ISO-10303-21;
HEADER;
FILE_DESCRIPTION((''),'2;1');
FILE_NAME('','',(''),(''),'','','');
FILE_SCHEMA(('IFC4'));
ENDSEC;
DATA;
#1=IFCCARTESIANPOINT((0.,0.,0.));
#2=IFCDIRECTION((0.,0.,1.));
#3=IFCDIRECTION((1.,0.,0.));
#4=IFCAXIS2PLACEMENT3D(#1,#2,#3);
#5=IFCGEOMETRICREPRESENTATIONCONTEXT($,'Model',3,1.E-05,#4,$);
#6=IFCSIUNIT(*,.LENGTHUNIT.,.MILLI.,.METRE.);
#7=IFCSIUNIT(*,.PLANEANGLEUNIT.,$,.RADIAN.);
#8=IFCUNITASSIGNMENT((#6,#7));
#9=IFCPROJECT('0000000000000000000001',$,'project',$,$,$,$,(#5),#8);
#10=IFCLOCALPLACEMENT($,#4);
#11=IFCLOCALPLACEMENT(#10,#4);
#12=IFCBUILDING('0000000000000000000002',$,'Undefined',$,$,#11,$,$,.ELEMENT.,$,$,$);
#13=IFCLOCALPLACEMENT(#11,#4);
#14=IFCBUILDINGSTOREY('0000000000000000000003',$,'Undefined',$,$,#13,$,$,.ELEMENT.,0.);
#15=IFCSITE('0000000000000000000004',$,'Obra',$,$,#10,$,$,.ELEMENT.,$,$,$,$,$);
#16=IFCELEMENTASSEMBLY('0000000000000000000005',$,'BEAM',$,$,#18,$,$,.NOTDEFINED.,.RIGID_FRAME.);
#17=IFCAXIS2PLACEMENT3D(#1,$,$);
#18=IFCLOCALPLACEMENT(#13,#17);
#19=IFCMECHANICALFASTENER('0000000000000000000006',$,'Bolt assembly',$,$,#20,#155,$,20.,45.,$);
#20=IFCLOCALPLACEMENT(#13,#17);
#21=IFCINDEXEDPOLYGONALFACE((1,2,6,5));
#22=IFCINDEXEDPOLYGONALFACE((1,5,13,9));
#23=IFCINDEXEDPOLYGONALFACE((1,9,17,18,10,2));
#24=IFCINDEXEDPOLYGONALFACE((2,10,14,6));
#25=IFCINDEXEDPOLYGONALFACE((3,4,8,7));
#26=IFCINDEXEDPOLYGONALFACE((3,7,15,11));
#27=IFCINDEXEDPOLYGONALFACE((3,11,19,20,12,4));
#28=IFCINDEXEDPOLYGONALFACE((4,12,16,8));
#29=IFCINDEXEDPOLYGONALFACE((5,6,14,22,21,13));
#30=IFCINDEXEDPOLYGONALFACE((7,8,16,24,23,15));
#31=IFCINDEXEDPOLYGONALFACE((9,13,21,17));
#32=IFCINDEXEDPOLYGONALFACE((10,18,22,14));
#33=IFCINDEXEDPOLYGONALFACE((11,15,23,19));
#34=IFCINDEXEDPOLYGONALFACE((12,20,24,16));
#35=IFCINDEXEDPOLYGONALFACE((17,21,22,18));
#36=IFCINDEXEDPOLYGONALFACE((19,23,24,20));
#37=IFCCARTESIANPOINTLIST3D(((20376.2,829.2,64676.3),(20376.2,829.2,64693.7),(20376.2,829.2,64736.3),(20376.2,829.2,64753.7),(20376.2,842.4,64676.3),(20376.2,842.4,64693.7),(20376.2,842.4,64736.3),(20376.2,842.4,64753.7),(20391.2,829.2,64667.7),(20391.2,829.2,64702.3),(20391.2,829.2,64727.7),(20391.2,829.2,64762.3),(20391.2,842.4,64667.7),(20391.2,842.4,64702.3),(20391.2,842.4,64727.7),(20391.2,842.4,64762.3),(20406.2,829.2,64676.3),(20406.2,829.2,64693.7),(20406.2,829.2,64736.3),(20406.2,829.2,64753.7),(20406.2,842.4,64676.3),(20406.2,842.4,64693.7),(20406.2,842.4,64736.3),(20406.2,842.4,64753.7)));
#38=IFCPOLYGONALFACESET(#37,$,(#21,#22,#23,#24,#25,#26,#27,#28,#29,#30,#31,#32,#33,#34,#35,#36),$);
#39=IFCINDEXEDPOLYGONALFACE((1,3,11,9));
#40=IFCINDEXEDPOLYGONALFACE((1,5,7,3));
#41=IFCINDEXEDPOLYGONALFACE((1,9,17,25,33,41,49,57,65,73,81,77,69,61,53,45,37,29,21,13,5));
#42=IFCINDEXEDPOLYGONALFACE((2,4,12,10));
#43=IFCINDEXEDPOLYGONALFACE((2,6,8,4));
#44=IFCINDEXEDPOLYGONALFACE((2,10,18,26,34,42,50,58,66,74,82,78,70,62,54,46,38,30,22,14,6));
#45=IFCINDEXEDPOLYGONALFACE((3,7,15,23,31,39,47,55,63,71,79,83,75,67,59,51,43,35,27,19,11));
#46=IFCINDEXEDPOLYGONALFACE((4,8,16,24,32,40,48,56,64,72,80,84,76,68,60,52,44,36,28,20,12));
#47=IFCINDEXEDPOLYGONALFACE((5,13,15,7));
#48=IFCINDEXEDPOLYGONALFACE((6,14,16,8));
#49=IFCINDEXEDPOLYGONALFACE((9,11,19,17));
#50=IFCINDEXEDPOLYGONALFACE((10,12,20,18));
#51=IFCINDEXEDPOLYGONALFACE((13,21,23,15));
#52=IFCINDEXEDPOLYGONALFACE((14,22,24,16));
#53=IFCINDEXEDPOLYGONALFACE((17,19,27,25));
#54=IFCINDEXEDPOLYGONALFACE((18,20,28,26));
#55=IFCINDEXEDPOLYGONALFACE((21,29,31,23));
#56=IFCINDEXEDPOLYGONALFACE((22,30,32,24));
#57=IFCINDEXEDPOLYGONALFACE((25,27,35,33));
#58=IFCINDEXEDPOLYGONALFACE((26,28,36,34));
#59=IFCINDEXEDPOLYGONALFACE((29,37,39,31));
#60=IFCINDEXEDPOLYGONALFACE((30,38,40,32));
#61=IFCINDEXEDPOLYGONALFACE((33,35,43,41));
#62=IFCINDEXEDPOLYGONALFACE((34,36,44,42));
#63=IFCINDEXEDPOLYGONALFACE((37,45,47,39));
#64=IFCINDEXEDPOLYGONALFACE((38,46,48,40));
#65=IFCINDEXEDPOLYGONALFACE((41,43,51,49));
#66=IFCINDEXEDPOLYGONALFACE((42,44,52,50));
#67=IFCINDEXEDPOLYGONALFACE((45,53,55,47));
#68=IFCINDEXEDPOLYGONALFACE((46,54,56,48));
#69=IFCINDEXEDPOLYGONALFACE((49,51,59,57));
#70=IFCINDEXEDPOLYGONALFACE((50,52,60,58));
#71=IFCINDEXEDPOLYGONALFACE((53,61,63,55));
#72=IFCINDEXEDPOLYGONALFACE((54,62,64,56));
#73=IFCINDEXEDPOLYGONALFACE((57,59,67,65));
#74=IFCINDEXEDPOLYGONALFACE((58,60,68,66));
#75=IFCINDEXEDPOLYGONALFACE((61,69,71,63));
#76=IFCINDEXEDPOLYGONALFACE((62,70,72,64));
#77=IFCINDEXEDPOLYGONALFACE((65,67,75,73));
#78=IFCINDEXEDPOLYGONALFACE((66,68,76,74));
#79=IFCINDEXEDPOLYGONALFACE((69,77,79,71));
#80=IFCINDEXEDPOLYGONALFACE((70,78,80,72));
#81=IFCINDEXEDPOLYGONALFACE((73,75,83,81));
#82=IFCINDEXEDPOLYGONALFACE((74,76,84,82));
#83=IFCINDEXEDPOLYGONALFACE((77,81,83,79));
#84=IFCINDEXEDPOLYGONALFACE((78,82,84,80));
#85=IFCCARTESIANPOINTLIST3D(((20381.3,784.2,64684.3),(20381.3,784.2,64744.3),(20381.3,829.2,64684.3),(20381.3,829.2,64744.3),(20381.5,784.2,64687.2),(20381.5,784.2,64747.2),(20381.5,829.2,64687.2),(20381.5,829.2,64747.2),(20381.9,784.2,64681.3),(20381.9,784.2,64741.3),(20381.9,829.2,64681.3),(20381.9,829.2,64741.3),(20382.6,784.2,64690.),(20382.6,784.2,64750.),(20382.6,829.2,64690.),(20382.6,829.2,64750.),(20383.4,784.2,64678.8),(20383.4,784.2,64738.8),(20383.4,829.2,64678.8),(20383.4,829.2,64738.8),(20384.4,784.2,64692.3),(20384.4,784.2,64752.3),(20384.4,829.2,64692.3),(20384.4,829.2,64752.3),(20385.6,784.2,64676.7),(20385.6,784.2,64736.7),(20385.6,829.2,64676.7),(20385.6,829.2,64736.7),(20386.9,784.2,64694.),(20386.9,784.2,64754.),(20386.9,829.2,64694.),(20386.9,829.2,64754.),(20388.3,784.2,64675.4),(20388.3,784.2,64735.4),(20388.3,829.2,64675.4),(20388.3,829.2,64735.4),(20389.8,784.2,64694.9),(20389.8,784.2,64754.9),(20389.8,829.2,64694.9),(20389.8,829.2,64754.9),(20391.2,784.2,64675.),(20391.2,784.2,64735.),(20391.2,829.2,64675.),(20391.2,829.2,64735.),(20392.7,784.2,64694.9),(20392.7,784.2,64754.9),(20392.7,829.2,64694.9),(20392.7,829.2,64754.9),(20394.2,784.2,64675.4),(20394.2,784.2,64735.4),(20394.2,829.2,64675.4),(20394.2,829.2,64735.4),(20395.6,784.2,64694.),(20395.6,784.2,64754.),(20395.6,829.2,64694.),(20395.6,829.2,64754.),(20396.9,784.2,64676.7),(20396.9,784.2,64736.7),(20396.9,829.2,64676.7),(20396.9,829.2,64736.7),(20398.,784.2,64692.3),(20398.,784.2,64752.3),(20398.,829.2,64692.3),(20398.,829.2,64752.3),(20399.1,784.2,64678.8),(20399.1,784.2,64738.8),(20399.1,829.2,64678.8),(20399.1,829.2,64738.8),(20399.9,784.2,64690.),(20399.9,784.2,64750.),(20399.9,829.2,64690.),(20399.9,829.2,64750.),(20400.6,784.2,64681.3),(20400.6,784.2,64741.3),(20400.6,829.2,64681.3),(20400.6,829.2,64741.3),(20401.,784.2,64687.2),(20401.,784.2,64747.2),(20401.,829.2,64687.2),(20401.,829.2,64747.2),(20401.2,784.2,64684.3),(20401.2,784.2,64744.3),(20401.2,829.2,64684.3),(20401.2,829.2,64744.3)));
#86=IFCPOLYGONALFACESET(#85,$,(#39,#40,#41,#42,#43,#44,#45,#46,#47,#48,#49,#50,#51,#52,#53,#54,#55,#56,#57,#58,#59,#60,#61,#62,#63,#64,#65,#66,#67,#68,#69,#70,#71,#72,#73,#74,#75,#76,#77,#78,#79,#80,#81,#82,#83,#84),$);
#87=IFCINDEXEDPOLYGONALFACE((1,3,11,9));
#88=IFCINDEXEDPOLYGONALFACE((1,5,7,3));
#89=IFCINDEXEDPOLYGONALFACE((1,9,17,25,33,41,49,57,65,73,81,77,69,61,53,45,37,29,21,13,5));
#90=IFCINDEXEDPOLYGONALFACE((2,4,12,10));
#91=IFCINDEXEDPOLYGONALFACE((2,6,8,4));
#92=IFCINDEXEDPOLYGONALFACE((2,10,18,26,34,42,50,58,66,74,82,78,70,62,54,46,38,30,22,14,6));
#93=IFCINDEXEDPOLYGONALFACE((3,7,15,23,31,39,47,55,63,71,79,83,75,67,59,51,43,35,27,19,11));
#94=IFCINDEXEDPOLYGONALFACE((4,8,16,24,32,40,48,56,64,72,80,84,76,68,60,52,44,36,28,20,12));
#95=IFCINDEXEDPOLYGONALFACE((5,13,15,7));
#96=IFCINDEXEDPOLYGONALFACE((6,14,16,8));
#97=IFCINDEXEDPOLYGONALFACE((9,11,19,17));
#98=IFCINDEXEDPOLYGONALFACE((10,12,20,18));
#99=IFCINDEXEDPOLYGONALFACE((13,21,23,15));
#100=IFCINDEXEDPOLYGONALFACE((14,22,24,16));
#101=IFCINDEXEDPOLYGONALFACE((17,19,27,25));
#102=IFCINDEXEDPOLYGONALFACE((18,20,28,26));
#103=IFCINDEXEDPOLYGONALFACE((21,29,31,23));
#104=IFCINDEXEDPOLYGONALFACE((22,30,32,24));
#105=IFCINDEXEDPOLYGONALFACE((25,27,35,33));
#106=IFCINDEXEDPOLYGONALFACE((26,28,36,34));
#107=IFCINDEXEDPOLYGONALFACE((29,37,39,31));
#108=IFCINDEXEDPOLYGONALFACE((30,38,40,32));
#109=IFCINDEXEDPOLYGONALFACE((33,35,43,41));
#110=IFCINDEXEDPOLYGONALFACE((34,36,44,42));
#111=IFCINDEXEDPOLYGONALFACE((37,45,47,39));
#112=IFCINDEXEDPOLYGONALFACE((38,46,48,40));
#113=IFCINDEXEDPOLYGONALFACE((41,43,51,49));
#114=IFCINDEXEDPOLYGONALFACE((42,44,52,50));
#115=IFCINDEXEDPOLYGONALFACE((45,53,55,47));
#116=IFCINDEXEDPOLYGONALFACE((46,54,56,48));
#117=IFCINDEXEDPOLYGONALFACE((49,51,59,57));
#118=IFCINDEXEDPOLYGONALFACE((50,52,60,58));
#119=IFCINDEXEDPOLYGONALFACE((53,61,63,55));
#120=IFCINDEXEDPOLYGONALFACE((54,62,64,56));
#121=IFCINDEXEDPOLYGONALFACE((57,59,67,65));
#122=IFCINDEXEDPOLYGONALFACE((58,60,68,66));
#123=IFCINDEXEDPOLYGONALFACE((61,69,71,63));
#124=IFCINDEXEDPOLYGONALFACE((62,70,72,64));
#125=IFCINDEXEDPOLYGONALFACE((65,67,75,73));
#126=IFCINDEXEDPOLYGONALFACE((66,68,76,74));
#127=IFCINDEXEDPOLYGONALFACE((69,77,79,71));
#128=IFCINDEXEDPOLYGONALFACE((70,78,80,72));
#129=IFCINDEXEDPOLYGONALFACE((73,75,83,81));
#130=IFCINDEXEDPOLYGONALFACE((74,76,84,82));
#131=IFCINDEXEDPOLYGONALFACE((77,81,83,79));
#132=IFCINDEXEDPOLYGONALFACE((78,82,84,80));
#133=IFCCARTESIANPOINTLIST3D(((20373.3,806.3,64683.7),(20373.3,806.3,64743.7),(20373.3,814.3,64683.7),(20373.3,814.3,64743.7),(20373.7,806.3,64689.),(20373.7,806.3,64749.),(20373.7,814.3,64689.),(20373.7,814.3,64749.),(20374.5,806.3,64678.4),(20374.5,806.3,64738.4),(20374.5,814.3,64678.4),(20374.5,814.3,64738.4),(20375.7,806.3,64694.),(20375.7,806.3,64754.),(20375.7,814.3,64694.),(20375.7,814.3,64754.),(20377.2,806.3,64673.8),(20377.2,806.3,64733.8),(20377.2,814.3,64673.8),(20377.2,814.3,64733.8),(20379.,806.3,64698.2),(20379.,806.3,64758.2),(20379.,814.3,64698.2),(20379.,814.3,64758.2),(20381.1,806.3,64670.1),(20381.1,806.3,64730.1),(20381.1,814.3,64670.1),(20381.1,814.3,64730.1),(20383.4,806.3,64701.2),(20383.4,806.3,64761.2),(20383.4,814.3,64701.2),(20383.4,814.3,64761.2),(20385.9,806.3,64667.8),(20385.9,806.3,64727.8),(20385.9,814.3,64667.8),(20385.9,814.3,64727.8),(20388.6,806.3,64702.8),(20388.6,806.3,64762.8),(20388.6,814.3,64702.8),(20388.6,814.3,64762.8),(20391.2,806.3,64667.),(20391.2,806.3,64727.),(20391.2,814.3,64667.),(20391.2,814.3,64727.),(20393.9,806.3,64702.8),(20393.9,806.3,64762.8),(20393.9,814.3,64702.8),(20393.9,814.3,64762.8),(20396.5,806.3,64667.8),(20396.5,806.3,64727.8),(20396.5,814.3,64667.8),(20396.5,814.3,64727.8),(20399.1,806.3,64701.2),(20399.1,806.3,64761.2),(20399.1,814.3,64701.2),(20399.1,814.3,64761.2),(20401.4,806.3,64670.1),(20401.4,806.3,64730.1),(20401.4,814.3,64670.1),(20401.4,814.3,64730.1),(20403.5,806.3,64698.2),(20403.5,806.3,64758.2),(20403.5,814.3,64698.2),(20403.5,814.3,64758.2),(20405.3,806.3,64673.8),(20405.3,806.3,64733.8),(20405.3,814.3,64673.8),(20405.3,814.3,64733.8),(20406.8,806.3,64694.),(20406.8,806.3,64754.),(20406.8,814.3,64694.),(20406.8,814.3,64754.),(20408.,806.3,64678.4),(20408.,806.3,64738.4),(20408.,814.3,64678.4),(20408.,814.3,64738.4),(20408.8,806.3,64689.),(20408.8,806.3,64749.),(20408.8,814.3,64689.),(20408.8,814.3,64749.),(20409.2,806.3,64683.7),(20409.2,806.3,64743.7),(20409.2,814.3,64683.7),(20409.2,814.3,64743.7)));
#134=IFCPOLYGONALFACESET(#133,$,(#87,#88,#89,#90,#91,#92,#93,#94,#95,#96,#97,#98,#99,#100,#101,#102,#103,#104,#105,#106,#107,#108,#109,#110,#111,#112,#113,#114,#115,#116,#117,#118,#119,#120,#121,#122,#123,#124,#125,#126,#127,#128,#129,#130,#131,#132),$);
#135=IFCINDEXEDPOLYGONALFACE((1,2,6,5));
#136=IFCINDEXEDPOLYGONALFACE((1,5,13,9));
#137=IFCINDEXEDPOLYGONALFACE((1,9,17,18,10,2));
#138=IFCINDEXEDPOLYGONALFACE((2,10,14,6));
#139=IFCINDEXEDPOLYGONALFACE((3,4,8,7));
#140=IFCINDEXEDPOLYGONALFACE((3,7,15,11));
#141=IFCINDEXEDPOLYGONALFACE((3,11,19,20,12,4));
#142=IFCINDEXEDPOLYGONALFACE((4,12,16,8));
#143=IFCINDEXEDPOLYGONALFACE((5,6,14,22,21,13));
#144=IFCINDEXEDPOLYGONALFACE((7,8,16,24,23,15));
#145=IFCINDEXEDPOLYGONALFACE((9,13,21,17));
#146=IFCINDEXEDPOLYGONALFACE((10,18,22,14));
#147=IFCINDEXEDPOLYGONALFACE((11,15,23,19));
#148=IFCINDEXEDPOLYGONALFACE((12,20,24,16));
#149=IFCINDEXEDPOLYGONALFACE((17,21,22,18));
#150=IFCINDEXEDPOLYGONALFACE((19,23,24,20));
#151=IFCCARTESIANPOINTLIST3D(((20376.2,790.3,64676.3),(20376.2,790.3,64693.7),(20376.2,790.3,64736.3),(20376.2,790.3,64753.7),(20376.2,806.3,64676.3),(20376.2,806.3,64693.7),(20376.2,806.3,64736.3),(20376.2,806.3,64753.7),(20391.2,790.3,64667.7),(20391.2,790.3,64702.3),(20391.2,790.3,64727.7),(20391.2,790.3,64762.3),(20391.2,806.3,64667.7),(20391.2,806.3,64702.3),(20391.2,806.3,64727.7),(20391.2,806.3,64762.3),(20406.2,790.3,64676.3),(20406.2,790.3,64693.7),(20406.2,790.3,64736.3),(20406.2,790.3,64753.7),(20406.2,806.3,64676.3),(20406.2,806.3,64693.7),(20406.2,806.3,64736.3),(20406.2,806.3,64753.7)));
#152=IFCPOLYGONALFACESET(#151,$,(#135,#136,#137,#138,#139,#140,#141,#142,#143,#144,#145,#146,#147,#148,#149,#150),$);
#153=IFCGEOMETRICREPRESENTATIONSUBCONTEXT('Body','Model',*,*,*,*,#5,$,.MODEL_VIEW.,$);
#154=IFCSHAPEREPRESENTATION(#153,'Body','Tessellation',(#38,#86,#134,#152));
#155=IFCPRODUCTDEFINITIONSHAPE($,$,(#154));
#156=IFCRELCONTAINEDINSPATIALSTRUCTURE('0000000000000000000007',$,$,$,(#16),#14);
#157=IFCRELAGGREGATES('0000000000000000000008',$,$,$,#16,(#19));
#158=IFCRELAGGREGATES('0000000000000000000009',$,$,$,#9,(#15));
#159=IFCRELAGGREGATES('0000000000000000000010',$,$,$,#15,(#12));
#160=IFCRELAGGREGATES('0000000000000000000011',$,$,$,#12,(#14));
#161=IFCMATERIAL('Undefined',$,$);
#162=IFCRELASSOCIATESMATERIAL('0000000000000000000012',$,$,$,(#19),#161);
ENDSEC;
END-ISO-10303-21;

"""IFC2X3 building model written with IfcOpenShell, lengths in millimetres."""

from ifc_helpers import new_model, si_unit, frame, origin_with_axes, origin_2d_with_axis, place, context, subcontext, project, spatial, polyline, circle, outline, extrude, source, transform, mapped, material, element, aggregate, save


model = new_model("IFC2X3")

# Units and contexts
model_context = context("Model", 3, precision=1e-05, world=origin_with_axes())
body_context = subcontext(model_context, "Body", "Model", "MODEL_VIEW")
ifc_project = project(units=[si_unit("LENGTHUNIT", "METRE", prefix="MILLI"), si_unit("PLANEANGLEUNIT", "RADIAN")], contexts=[model_context])

# Site, building, storey
site_placement = place(None, origin_with_axes())
site = spatial("IfcSite", under=ifc_project, at=site_placement, Name="Obra", CompositionType="ELEMENT")
building_placement = place(site_placement, origin_with_axes())
building = spatial("IfcBuilding", under=site, at=building_placement, Name="Undefined", CompositionType="ELEMENT")
storey_placement = place(building_placement, origin_with_axes())
storey = spatial("IfcBuildingStorey", under=building, at=storey_placement, Name="Undefined", CompositionType="ELEMENT", Elevation=0.0)

# Shared definitions
ifc_material = material(Name="Undefined")

# Element assembly, mechanical fastener
assembly_1_placement = place(storey_placement, origin_with_axes())
assembly_1 = element("IfcElementAssembly", 1, at=assembly_1_placement, inside=storey, Name="BEAM", AssemblyPlace="NOTDEFINED", PredefinedType="RIGID_FRAME")
shared_shape_1 = source(origin_with_axes(), body_context, "Body", "SweptSolid", [
    extrude(outline(polyline([(17.3, 0.0), (8.7, 15.0), (-8.7, 15.0), (-17.3, 0.0), (-8.7, -15.0), (8.7, -15.0), (17.3, 0.0)])), frame((0.0, -24.7, 0.0), z_axis=(0.0, 1.0, 0.0), x_axis=(1.0, 0.0, 0.0)), (0.0, 0.0, 1.0), 13.2),
    extrude(circle(Radius=10.0, at=origin_2d_with_axis()), frame((0.0, -11.5, 0.0), z_axis=(0.0, 1.0, 0.0), x_axis=(1.0, 0.0, 0.0)), (0.0, 0.0, 1.0), 45.0),
    extrude(circle(Radius=18.0, at=origin_2d_with_axis()), frame((0.0, 3.3, 0.0), z_axis=(0.0, 1.0, 0.0), x_axis=(1.0, 0.0, 0.0)), (0.0, 0.0, 1.0), 8.0),
    extrude(outline(polyline([(17.3, 0.0), (8.7, 15.0), (-8.7, 15.0), (-17.3, 0.0), (-8.7, -15.0), (8.7, -15.0), (17.3, 0.0)])), frame((0.0, 11.3, 0.0), z_axis=(0.0, 1.0, 0.0), x_axis=(1.0, 0.0, 0.0)), (0.0, 0.0, 1.0), 16.0),
])
mechanical_fastener_1_placement = place(assembly_1_placement, frame((20431.2, 817.6, 64850.0), z_axis=(-1.0, 0.0, 0.0), x_axis=(0.0, 0.0, -1.0)))
mechanical_fastener_1 = element("IfcMechanicalFastener", 2, at=mechanical_fastener_1_placement, material=ifc_material, Name="Bolt assembly", NominalDiameter=20.0, NominalLength=45.0, context=body_context, shape_type="MappedRepresentation", body=[
    mapped(shared_shape_1, transform((105.0, 0.0, 40.0))),
    mapped(shared_shape_1, transform((165.0, 0.0, 40.0))),
])
aggregate(assembly_1, [mechanical_fastener_1])

save(model, "model.ifc")
